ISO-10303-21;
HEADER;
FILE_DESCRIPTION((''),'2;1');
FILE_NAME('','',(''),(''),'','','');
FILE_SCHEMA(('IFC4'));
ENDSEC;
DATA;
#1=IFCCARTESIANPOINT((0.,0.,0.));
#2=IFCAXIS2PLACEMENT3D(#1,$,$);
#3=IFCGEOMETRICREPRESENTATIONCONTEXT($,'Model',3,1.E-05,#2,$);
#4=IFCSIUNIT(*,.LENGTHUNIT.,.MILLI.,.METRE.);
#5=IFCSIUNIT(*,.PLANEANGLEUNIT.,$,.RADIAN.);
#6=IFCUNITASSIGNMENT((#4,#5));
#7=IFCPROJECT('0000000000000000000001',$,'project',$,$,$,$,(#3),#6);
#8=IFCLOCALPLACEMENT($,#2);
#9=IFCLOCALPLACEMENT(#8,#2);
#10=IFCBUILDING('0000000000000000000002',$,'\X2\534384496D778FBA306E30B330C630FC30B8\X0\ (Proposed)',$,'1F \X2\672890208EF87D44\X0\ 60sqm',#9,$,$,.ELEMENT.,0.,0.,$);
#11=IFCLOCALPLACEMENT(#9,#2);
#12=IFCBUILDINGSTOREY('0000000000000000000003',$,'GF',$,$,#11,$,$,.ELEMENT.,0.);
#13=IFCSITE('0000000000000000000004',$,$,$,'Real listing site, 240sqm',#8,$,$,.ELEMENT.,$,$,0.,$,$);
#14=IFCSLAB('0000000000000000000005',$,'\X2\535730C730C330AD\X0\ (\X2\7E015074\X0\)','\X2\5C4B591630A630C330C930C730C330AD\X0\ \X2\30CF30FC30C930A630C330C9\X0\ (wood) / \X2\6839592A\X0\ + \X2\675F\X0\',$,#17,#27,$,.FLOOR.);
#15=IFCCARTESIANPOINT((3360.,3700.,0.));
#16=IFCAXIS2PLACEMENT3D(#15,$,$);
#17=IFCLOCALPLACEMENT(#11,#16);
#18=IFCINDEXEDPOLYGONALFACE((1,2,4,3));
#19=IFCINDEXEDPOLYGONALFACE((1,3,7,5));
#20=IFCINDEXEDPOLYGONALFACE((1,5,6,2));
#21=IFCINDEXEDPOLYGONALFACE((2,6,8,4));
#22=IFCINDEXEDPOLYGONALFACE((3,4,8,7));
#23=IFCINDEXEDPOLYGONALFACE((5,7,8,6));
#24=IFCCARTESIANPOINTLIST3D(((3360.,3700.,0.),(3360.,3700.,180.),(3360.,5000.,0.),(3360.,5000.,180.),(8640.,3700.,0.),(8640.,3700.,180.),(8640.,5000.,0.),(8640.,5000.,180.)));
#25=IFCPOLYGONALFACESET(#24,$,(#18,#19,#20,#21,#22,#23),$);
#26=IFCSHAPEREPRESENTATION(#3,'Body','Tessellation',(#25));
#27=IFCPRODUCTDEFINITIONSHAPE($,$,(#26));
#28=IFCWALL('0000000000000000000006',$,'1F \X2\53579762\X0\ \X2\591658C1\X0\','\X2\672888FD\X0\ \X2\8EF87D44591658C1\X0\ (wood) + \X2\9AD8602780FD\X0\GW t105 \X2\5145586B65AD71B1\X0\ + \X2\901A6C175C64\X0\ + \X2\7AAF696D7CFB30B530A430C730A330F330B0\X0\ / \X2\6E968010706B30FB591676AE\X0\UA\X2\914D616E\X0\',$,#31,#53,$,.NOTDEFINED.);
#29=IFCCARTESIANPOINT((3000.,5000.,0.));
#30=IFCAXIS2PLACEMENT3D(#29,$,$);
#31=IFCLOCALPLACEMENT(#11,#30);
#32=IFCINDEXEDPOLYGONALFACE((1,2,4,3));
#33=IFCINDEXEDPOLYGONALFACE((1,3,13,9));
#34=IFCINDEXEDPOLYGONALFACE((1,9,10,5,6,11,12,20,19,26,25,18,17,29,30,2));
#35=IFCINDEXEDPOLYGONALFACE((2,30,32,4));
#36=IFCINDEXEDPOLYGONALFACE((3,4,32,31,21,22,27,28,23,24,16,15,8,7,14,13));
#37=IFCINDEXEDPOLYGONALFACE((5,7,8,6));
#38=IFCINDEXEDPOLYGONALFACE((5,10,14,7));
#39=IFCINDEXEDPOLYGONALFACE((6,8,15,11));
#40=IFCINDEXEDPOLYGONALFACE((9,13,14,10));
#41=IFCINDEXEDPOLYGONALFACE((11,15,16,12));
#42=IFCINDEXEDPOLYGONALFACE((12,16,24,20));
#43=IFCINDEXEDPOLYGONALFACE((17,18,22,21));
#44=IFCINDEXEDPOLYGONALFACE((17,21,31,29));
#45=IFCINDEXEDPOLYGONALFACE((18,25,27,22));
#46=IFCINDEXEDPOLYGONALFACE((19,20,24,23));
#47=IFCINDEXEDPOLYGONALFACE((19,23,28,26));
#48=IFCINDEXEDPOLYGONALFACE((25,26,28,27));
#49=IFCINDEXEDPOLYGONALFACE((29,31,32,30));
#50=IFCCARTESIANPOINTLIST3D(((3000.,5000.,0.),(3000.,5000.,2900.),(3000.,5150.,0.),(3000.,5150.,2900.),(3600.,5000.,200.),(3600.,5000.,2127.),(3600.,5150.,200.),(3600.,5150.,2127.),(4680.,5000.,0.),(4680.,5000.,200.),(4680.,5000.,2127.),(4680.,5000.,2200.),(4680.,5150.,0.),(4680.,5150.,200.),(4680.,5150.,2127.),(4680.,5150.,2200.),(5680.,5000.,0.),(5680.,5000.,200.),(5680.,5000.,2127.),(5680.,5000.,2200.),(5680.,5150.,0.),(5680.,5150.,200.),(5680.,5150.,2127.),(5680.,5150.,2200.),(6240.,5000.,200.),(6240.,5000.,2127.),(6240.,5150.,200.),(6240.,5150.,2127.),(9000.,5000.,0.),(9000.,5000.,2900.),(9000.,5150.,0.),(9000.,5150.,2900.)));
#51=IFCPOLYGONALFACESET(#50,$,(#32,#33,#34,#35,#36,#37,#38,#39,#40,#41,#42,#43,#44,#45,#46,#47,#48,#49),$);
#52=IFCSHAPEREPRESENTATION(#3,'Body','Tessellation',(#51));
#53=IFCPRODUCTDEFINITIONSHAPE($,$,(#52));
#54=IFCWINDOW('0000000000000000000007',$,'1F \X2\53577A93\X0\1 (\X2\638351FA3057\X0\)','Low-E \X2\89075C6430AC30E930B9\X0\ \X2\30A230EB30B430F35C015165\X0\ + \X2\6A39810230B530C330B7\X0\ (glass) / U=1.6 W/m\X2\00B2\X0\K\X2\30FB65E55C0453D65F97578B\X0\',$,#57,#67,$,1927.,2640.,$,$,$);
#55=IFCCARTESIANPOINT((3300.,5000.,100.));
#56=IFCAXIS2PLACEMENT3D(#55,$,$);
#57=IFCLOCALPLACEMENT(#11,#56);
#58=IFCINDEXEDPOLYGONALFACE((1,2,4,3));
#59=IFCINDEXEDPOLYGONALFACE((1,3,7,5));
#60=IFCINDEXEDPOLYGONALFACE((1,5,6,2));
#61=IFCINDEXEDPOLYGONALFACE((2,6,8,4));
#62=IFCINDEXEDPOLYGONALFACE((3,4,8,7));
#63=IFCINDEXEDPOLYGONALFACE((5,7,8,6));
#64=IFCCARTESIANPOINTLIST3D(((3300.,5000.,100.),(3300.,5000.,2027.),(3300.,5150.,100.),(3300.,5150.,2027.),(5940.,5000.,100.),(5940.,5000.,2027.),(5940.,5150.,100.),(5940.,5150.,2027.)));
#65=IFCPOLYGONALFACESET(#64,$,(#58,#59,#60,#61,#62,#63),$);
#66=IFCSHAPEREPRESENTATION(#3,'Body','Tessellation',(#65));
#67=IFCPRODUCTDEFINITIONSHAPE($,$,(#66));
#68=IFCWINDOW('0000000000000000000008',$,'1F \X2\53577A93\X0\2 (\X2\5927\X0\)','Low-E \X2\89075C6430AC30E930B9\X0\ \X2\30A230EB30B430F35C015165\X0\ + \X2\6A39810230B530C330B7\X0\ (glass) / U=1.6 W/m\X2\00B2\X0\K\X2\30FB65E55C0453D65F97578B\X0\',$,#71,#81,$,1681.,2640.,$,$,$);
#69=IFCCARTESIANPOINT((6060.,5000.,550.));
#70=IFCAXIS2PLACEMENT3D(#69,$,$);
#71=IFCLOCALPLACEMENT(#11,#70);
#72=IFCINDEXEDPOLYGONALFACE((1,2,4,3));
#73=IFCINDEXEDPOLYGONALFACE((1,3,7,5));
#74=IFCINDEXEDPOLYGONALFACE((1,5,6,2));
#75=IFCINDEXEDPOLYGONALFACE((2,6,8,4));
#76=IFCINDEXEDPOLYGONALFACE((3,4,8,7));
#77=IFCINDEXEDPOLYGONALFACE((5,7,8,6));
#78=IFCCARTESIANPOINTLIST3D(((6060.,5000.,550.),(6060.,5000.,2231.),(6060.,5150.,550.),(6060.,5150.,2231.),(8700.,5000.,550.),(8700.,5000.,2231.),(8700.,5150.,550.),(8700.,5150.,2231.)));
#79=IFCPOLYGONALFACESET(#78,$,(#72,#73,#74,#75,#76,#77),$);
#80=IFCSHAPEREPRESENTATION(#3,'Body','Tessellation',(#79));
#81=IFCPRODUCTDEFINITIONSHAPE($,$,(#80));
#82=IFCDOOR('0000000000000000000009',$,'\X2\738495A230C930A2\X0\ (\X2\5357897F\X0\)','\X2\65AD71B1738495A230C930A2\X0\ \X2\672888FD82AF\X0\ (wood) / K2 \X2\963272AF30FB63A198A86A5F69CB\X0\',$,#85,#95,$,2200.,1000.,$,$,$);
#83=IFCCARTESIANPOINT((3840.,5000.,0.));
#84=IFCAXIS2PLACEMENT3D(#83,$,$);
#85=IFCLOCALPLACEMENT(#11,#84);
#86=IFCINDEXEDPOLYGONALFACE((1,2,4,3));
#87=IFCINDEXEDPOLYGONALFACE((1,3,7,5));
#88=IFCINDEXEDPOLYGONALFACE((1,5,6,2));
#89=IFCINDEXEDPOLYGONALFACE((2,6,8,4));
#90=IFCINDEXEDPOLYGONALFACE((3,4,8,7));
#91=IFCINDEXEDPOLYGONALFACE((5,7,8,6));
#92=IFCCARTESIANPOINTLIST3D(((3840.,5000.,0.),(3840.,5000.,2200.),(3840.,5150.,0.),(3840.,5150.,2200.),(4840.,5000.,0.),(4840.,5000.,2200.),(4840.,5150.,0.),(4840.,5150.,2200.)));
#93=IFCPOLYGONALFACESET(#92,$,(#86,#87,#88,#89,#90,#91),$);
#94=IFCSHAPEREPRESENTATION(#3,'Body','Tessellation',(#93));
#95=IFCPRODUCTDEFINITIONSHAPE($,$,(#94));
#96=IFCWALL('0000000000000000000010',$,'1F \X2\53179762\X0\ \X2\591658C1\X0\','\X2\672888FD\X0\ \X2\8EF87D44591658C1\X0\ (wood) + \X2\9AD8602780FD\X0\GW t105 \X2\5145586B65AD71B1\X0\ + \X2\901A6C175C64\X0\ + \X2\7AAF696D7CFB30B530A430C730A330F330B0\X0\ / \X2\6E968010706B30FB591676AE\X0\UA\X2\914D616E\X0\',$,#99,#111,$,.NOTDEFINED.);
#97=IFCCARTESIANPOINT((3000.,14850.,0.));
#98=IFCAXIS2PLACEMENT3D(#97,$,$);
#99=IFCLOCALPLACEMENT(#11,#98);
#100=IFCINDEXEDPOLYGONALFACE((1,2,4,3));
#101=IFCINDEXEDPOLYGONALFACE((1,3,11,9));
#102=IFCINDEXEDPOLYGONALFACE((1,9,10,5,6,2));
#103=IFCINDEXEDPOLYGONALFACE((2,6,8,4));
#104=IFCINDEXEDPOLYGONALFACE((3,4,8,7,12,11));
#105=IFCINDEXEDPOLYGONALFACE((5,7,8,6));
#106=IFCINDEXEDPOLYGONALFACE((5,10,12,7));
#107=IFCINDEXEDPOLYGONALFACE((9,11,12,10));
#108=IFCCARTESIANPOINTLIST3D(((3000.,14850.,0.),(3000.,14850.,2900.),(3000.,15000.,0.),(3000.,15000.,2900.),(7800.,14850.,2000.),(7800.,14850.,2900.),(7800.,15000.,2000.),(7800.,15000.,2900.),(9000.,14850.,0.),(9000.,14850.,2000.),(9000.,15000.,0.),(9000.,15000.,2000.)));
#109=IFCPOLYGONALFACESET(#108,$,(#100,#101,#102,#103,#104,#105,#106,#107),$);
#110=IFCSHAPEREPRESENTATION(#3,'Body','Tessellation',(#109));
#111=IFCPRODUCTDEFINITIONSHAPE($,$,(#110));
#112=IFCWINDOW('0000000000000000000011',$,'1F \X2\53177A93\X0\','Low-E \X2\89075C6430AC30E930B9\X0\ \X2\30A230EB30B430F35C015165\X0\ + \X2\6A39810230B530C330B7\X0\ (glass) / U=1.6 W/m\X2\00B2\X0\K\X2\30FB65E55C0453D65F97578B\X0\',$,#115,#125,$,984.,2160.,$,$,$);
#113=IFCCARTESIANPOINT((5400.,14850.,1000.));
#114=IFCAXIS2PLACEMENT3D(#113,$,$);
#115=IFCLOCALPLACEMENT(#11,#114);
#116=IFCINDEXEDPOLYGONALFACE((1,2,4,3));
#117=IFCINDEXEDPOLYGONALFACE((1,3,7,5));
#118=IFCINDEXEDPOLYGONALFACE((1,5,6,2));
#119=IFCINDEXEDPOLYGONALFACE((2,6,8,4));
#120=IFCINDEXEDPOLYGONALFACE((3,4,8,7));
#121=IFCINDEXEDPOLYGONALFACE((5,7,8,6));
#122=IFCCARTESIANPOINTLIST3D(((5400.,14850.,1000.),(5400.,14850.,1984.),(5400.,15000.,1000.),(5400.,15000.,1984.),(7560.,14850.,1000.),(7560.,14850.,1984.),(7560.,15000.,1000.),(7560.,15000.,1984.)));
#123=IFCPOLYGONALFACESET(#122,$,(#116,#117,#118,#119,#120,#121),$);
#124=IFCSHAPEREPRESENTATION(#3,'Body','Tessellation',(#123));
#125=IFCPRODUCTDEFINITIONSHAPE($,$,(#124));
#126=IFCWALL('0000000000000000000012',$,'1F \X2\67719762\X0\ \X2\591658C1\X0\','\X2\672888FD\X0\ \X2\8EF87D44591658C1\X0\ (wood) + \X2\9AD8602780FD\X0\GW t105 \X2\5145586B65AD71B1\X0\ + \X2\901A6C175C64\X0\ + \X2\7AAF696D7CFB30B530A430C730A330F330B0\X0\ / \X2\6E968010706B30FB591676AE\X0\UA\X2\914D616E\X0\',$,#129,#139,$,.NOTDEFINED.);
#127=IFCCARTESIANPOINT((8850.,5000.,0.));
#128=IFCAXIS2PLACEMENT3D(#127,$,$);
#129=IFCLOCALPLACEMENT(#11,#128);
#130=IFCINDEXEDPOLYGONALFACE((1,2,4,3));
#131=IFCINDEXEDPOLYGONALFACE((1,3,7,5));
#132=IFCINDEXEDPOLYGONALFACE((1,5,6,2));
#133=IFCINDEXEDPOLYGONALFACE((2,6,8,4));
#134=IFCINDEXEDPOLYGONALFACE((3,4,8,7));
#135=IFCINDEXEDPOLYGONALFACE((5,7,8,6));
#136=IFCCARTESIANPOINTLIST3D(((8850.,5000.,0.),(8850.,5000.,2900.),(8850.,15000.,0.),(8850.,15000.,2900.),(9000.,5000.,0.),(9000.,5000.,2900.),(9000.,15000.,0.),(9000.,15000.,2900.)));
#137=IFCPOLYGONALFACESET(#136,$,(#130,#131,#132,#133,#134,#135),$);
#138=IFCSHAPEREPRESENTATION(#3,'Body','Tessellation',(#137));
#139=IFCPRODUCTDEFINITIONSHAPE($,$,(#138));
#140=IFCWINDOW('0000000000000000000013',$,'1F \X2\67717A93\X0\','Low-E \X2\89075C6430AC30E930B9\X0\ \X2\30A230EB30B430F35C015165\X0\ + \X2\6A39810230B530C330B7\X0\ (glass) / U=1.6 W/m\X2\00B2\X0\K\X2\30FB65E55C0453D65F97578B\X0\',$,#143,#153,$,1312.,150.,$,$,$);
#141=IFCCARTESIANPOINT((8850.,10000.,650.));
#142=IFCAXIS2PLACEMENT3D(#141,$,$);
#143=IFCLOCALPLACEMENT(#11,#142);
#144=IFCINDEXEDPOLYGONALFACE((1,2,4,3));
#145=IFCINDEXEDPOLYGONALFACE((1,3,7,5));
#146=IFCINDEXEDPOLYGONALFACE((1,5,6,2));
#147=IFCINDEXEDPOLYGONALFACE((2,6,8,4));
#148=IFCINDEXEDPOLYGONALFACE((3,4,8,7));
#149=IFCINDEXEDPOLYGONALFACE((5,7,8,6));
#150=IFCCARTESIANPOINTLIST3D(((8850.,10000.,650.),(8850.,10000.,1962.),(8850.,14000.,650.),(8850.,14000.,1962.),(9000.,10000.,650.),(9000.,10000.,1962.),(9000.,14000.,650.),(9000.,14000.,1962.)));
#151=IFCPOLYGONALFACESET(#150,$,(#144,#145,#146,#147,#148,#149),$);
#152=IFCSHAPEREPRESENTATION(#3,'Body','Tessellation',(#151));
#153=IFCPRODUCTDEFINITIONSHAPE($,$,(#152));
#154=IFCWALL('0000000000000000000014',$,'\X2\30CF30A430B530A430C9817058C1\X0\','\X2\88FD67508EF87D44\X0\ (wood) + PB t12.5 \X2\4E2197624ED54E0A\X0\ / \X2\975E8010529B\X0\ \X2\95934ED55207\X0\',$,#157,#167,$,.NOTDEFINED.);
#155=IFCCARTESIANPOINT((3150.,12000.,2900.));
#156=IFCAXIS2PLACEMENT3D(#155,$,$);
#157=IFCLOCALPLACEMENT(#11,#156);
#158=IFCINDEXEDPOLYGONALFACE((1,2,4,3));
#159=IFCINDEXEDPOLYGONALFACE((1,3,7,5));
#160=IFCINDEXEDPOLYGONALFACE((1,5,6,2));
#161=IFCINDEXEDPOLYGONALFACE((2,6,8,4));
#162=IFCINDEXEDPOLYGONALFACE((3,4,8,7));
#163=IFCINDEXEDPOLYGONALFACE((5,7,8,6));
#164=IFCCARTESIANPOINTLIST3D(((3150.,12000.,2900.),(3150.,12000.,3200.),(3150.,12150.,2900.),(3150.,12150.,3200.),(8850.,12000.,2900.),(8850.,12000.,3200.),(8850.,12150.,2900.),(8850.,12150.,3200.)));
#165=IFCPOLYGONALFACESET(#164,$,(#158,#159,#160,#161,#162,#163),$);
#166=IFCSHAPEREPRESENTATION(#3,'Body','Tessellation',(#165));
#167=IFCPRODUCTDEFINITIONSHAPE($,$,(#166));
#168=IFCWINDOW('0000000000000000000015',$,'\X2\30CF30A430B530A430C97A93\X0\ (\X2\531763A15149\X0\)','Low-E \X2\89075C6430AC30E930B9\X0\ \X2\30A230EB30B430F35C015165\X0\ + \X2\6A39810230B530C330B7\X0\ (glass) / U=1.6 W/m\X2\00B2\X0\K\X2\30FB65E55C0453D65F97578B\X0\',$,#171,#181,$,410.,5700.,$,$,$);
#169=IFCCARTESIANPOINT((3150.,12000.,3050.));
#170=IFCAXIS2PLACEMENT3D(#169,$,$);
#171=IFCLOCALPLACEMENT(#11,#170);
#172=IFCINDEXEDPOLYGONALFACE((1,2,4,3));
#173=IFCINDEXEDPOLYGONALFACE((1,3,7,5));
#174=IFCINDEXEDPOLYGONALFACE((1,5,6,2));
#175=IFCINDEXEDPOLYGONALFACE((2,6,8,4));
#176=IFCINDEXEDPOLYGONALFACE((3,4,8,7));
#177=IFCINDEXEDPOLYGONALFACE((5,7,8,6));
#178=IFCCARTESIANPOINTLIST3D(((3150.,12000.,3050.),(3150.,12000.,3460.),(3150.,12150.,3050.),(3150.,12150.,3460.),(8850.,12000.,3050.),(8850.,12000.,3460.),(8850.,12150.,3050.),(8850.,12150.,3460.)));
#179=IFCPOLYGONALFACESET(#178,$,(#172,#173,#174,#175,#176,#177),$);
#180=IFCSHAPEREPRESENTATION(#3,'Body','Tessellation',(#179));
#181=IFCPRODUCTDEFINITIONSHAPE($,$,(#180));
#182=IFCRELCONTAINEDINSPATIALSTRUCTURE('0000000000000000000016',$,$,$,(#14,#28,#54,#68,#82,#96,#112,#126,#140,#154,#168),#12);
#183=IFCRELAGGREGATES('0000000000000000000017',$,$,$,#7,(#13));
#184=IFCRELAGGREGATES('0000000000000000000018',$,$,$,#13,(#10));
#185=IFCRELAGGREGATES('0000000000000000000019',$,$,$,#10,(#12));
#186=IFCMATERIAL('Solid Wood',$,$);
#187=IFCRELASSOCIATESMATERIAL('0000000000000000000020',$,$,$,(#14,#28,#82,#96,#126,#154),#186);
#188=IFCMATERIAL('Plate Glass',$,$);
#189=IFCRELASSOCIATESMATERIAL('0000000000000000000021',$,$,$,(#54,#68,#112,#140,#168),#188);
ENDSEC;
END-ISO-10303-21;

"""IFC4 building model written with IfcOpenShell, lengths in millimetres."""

from ifc_helpers import new_model, si_unit, frame, frame_2d, origin, place, context, project, spatial, rectangle, extrude, material, element, fill, save


model = new_model("IFC4")

# Units and contexts
model_context = context("Model", 3, precision=1e-05, world=origin())
ifc_project = project(units=[si_unit("LENGTHUNIT", "METRE", prefix="MILLI"), si_unit("PLANEANGLEUNIT", "RADIAN")], contexts=[model_context])

# Site, building, storey
site_placement = place(None, origin())
site = spatial("IfcSite", under=ifc_project, at=site_placement, ObjectType="Real listing site, 240sqm", CompositionType="ELEMENT", RefElevation=0.0)
building_placement = place(site_placement, origin())
building = spatial("IfcBuilding", under=site, at=building_placement, Name="千葉海辺のコテージ (Proposed)", ObjectType="1F 木造軸組 60sqm", CompositionType="ELEMENT", ElevationOfRefHeight=0.0, ElevationOfTerrain=0.0)
storey_placement = place(building_placement, origin())
storey = spatial("IfcBuildingStorey", under=building, at=storey_placement, Name="GF", CompositionType="ELEMENT", Elevation=0.0)

# Slab
ifc_material_1 = material(Name="Solid Wood")
slab_1_placement = place(storey_placement, frame((3360.0, 3700.0, 0.0)))
element("IfcSlab", 1, at=slab_1_placement, inside=storey, material=ifc_material_1, Name="南デッキ (縁側)", Description="屋外ウッドデッキ ハードウッド (wood) / 根太 + 束", PredefinedType="FLOOR", context=model_context, shape_type="SweptSolid", body=[
    extrude(rectangle(XDim=5280.0, YDim=1300.0, at=frame_2d((2640.0, 650.0))), frame((3360.0, 3700.0, 0.0)), (0.0, 0.0, 1.0), 180.0),
])

# Wall, openings, windows, door
wall_1_placement = place(storey_placement, frame((3000.0, 5000.0, 0.0)))
wall_1 = element("IfcWall", 2, at=wall_1_placement, inside=storey, material=ifc_material_1, Name="1F 南面 外壁", Description="木製 軸組外壁 (wood) + 高性能GW t105 充填断熱 + 通気層 + 窯業系サイディング / 準耐火・外皮UA配慮", PredefinedType="NOTDEFINED", context=model_context, shape_type="SweptSolid", body=[
    extrude(rectangle(XDim=6000.0, YDim=150.0, at=frame_2d((3000.0, 75.0))), frame((3000.0, 5000.0, 0.0)), (0.0, 0.0, 1.0), 2900.0),
])
opening_1_placement = place(storey_placement, frame((3300.0, 5000.0, 100.0)))
opening_1 = element("IfcOpeningElement", 3, at=opening_1_placement, cuts=wall_1, PredefinedType="NOTDEFINED", context=model_context, shape_type="SweptSolid", body=[
    extrude(rectangle(XDim=2640.0, YDim=150.0, at=frame_2d((1320.0, 75.0))), frame((3300.0, 5000.0, 100.0)), (0.0, 0.0, 1.0), 1927.0),
])
opening_2_placement = place(storey_placement, frame((6060.0, 5000.0, 550.0)))
opening_2 = element("IfcOpeningElement", 4, at=opening_2_placement, cuts=wall_1, PredefinedType="NOTDEFINED", context=model_context, shape_type="SweptSolid", body=[
    extrude(rectangle(XDim=2640.0, YDim=150.0, at=frame_2d((1320.0, 75.0))), frame((6060.0, 5000.0, 550.0)), (0.0, 0.0, 1.0), 1681.0),
])
opening_3_placement = place(storey_placement, frame((3840.0, 5000.0, 0.0)))
opening_3 = element("IfcOpeningElement", 5, at=opening_3_placement, cuts=wall_1, PredefinedType="NOTDEFINED", context=model_context, shape_type="SweptSolid", body=[
    extrude(rectangle(XDim=1000.0, YDim=150.0, at=frame_2d((500.0, 75.0))), frame((3840.0, 5000.0, 0.0)), (0.0, 0.0, 1.0), 2200.0),
])
ifc_material_2 = material(Name="Plate Glass")
window_1_placement = place(storey_placement, frame((3300.0, 5000.0, 100.0)))
window_1 = element("IfcWindow", 6, at=window_1_placement, inside=storey, material=ifc_material_2, Name="1F 南窓1 (掃出し)", Description="Low-E 複層ガラス アルゴン封入 + 樹脂サッシ (glass) / U=1.6 W/m²K・日射取得型", OverallHeight=1927.0, OverallWidth=2640.0, context=model_context, shape_type="SweptSolid", body=[
    extrude(rectangle(XDim=2640.0, YDim=150.0, at=frame_2d((1320.0, 75.0))), frame((3300.0, 5000.0, 100.0)), (0.0, 0.0, 1.0), 1927.0),
])
fill(opening_1, window_1)
window_2_placement = place(storey_placement, frame((6060.0, 5000.0, 550.0)))
window_2 = element("IfcWindow", 7, at=window_2_placement, inside=storey, material=ifc_material_2, Name="1F 南窓2 (大)", Description="Low-E 複層ガラス アルゴン封入 + 樹脂サッシ (glass) / U=1.6 W/m²K・日射取得型", OverallHeight=1681.0, OverallWidth=2640.0, context=model_context, shape_type="SweptSolid", body=[
    extrude(rectangle(XDim=2640.0, YDim=150.0, at=frame_2d((1320.0, 75.0))), frame((6060.0, 5000.0, 550.0)), (0.0, 0.0, 1.0), 1681.0),
])
fill(opening_2, window_2)
door_placement = place(storey_placement, frame((3840.0, 5000.0, 0.0)))
door = element("IfcDoor", 8, at=door_placement, inside=storey, material=ifc_material_1, Name="玄関ドア (南西)", Description="断熱玄関ドア 木製芯 (wood) / K2 防犯・採風機構", OverallHeight=2200.0, OverallWidth=1000.0, context=model_context, shape_type="SweptSolid", body=[
    extrude(rectangle(XDim=1000.0, YDim=150.0, at=frame_2d((500.0, 75.0))), frame((3840.0, 5000.0, 0.0)), (0.0, 0.0, 1.0), 2200.0),
])
fill(opening_3, door)

# Walls, openings, windows
wall_2_placement = place(storey_placement, frame((3000.0, 14850.0, 0.0)))
wall_2 = element("IfcWall", 9, at=wall_2_placement, inside=storey, material=ifc_material_1, Name="1F 北面 外壁", Description="木製 軸組外壁 (wood) + 高性能GW t105 充填断熱 + 通気層 + 窯業系サイディング / 準耐火・外皮UA配慮", PredefinedType="NOTDEFINED", context=model_context, shape_type="SweptSolid", body=[
    extrude(rectangle(XDim=6000.0, YDim=150.0, at=frame_2d((3000.0, 75.0))), frame((3000.0, 14850.0, 0.0)), (0.0, 0.0, 1.0), 2900.0),
])
opening_4_placement = place(storey_placement, frame((5400.0, 14850.0, 1000.0)))
opening_4 = element("IfcOpeningElement", 10, at=opening_4_placement, cuts=wall_2, PredefinedType="NOTDEFINED", context=model_context, shape_type="SweptSolid", body=[
    extrude(rectangle(XDim=2160.0, YDim=150.0, at=frame_2d((1080.0, 75.0))), frame((5400.0, 14850.0, 1000.0)), (0.0, 0.0, 1.0), 984.0),
])
window_3_placement = place(storey_placement, frame((5400.0, 14850.0, 1000.0)))
window_3 = element("IfcWindow", 11, at=window_3_placement, inside=storey, material=ifc_material_2, Name="1F 北窓", Description="Low-E 複層ガラス アルゴン封入 + 樹脂サッシ (glass) / U=1.6 W/m²K・日射取得型", OverallHeight=984.0, OverallWidth=2160.0, context=model_context, shape_type="SweptSolid", body=[
    extrude(rectangle(XDim=2160.0, YDim=150.0, at=frame_2d((1080.0, 75.0))), frame((5400.0, 14850.0, 1000.0)), (0.0, 0.0, 1.0), 984.0),
])
fill(opening_4, window_3)
wall_3_placement = place(storey_placement, frame((8850.0, 5000.0, 0.0)))
wall_3 = element("IfcWall", 12, at=wall_3_placement, inside=storey, material=ifc_material_1, Name="1F 東面 外壁", Description="木製 軸組外壁 (wood) + 高性能GW t105 充填断熱 + 通気層 + 窯業系サイディング / 準耐火・外皮UA配慮", PredefinedType="NOTDEFINED", context=model_context, shape_type="SweptSolid", body=[
    extrude(rectangle(XDim=150.0, YDim=10000.0, at=frame_2d((75.0, 5000.0))), frame((8850.0, 5000.0, 0.0)), (0.0, 0.0, 1.0), 2900.0),
])
opening_5_placement = place(storey_placement, frame((8850.0, 10000.0, 650.0)))
opening_5 = element("IfcOpeningElement", 13, at=opening_5_placement, cuts=wall_3, PredefinedType="NOTDEFINED", context=model_context, shape_type="SweptSolid", body=[
    extrude(rectangle(XDim=150.0, YDim=4000.0, at=frame_2d((75.0, 2000.0))), frame((8850.0, 10000.0, 650.0)), (0.0, 0.0, 1.0), 1312.0),
])
window_4_placement = place(storey_placement, frame((8850.0, 10000.0, 650.0)))
window_4 = element("IfcWindow", 14, at=window_4_placement, inside=storey, material=ifc_material_2, Name="1F 東窓", Description="Low-E 複層ガラス アルゴン封入 + 樹脂サッシ (glass) / U=1.6 W/m²K・日射取得型", OverallHeight=1312.0, OverallWidth=150.0, context=model_context, shape_type="SweptSolid", body=[
    extrude(rectangle(XDim=150.0, YDim=4000.0, at=frame_2d((75.0, 2000.0))), frame((8850.0, 10000.0, 650.0)), (0.0, 0.0, 1.0), 1312.0),
])
fill(opening_5, window_4)

# Wall, opening, window
wall_4_placement = place(storey_placement, frame((3150.0, 12000.0, 2900.0)))
wall_4 = element("IfcWall", 15, at=wall_4_placement, inside=storey, material=ifc_material_1, Name="ハイサイド腰壁", Description="製材軸組 (wood) + PB t12.5 両面仕上 / 非耐力 間仕切", PredefinedType="NOTDEFINED", context=model_context, shape_type="SweptSolid", body=[
    extrude(rectangle(XDim=5700.0, YDim=150.0, at=frame_2d((2850.0, 75.0))), frame((3150.0, 12000.0, 2900.0)), (0.0, 0.0, 1.0), 700.0),
])
opening_6_placement = place(storey_placement, frame((3150.0, 12000.0, 3050.0)))
opening_6 = element("IfcOpeningElement", 16, at=opening_6_placement, cuts=wall_4, PredefinedType="NOTDEFINED", context=model_context, shape_type="SweptSolid", body=[
    extrude(rectangle(XDim=5700.0, YDim=150.0, at=frame_2d((2850.0, 75.0))), frame((3150.0, 12000.0, 3050.0)), (0.0, 0.0, 1.0), 410.0),
])
window_5_placement = place(storey_placement, frame((3150.0, 12000.0, 3050.0)))
window_5 = element("IfcWindow", 17, at=window_5_placement, inside=storey, material=ifc_material_2, Name="ハイサイド窓 (北採光)", Description="Low-E 複層ガラス アルゴン封入 + 樹脂サッシ (glass) / U=1.6 W/m²K・日射取得型", OverallHeight=410.0, OverallWidth=5700.0, context=model_context, shape_type="SweptSolid", body=[
    extrude(rectangle(XDim=5700.0, YDim=150.0, at=frame_2d((2850.0, 75.0))), frame((3150.0, 12000.0, 3050.0)), (0.0, 0.0, 1.0), 410.0),
])
fill(opening_6, window_5)

save(model, "model.ifc")
